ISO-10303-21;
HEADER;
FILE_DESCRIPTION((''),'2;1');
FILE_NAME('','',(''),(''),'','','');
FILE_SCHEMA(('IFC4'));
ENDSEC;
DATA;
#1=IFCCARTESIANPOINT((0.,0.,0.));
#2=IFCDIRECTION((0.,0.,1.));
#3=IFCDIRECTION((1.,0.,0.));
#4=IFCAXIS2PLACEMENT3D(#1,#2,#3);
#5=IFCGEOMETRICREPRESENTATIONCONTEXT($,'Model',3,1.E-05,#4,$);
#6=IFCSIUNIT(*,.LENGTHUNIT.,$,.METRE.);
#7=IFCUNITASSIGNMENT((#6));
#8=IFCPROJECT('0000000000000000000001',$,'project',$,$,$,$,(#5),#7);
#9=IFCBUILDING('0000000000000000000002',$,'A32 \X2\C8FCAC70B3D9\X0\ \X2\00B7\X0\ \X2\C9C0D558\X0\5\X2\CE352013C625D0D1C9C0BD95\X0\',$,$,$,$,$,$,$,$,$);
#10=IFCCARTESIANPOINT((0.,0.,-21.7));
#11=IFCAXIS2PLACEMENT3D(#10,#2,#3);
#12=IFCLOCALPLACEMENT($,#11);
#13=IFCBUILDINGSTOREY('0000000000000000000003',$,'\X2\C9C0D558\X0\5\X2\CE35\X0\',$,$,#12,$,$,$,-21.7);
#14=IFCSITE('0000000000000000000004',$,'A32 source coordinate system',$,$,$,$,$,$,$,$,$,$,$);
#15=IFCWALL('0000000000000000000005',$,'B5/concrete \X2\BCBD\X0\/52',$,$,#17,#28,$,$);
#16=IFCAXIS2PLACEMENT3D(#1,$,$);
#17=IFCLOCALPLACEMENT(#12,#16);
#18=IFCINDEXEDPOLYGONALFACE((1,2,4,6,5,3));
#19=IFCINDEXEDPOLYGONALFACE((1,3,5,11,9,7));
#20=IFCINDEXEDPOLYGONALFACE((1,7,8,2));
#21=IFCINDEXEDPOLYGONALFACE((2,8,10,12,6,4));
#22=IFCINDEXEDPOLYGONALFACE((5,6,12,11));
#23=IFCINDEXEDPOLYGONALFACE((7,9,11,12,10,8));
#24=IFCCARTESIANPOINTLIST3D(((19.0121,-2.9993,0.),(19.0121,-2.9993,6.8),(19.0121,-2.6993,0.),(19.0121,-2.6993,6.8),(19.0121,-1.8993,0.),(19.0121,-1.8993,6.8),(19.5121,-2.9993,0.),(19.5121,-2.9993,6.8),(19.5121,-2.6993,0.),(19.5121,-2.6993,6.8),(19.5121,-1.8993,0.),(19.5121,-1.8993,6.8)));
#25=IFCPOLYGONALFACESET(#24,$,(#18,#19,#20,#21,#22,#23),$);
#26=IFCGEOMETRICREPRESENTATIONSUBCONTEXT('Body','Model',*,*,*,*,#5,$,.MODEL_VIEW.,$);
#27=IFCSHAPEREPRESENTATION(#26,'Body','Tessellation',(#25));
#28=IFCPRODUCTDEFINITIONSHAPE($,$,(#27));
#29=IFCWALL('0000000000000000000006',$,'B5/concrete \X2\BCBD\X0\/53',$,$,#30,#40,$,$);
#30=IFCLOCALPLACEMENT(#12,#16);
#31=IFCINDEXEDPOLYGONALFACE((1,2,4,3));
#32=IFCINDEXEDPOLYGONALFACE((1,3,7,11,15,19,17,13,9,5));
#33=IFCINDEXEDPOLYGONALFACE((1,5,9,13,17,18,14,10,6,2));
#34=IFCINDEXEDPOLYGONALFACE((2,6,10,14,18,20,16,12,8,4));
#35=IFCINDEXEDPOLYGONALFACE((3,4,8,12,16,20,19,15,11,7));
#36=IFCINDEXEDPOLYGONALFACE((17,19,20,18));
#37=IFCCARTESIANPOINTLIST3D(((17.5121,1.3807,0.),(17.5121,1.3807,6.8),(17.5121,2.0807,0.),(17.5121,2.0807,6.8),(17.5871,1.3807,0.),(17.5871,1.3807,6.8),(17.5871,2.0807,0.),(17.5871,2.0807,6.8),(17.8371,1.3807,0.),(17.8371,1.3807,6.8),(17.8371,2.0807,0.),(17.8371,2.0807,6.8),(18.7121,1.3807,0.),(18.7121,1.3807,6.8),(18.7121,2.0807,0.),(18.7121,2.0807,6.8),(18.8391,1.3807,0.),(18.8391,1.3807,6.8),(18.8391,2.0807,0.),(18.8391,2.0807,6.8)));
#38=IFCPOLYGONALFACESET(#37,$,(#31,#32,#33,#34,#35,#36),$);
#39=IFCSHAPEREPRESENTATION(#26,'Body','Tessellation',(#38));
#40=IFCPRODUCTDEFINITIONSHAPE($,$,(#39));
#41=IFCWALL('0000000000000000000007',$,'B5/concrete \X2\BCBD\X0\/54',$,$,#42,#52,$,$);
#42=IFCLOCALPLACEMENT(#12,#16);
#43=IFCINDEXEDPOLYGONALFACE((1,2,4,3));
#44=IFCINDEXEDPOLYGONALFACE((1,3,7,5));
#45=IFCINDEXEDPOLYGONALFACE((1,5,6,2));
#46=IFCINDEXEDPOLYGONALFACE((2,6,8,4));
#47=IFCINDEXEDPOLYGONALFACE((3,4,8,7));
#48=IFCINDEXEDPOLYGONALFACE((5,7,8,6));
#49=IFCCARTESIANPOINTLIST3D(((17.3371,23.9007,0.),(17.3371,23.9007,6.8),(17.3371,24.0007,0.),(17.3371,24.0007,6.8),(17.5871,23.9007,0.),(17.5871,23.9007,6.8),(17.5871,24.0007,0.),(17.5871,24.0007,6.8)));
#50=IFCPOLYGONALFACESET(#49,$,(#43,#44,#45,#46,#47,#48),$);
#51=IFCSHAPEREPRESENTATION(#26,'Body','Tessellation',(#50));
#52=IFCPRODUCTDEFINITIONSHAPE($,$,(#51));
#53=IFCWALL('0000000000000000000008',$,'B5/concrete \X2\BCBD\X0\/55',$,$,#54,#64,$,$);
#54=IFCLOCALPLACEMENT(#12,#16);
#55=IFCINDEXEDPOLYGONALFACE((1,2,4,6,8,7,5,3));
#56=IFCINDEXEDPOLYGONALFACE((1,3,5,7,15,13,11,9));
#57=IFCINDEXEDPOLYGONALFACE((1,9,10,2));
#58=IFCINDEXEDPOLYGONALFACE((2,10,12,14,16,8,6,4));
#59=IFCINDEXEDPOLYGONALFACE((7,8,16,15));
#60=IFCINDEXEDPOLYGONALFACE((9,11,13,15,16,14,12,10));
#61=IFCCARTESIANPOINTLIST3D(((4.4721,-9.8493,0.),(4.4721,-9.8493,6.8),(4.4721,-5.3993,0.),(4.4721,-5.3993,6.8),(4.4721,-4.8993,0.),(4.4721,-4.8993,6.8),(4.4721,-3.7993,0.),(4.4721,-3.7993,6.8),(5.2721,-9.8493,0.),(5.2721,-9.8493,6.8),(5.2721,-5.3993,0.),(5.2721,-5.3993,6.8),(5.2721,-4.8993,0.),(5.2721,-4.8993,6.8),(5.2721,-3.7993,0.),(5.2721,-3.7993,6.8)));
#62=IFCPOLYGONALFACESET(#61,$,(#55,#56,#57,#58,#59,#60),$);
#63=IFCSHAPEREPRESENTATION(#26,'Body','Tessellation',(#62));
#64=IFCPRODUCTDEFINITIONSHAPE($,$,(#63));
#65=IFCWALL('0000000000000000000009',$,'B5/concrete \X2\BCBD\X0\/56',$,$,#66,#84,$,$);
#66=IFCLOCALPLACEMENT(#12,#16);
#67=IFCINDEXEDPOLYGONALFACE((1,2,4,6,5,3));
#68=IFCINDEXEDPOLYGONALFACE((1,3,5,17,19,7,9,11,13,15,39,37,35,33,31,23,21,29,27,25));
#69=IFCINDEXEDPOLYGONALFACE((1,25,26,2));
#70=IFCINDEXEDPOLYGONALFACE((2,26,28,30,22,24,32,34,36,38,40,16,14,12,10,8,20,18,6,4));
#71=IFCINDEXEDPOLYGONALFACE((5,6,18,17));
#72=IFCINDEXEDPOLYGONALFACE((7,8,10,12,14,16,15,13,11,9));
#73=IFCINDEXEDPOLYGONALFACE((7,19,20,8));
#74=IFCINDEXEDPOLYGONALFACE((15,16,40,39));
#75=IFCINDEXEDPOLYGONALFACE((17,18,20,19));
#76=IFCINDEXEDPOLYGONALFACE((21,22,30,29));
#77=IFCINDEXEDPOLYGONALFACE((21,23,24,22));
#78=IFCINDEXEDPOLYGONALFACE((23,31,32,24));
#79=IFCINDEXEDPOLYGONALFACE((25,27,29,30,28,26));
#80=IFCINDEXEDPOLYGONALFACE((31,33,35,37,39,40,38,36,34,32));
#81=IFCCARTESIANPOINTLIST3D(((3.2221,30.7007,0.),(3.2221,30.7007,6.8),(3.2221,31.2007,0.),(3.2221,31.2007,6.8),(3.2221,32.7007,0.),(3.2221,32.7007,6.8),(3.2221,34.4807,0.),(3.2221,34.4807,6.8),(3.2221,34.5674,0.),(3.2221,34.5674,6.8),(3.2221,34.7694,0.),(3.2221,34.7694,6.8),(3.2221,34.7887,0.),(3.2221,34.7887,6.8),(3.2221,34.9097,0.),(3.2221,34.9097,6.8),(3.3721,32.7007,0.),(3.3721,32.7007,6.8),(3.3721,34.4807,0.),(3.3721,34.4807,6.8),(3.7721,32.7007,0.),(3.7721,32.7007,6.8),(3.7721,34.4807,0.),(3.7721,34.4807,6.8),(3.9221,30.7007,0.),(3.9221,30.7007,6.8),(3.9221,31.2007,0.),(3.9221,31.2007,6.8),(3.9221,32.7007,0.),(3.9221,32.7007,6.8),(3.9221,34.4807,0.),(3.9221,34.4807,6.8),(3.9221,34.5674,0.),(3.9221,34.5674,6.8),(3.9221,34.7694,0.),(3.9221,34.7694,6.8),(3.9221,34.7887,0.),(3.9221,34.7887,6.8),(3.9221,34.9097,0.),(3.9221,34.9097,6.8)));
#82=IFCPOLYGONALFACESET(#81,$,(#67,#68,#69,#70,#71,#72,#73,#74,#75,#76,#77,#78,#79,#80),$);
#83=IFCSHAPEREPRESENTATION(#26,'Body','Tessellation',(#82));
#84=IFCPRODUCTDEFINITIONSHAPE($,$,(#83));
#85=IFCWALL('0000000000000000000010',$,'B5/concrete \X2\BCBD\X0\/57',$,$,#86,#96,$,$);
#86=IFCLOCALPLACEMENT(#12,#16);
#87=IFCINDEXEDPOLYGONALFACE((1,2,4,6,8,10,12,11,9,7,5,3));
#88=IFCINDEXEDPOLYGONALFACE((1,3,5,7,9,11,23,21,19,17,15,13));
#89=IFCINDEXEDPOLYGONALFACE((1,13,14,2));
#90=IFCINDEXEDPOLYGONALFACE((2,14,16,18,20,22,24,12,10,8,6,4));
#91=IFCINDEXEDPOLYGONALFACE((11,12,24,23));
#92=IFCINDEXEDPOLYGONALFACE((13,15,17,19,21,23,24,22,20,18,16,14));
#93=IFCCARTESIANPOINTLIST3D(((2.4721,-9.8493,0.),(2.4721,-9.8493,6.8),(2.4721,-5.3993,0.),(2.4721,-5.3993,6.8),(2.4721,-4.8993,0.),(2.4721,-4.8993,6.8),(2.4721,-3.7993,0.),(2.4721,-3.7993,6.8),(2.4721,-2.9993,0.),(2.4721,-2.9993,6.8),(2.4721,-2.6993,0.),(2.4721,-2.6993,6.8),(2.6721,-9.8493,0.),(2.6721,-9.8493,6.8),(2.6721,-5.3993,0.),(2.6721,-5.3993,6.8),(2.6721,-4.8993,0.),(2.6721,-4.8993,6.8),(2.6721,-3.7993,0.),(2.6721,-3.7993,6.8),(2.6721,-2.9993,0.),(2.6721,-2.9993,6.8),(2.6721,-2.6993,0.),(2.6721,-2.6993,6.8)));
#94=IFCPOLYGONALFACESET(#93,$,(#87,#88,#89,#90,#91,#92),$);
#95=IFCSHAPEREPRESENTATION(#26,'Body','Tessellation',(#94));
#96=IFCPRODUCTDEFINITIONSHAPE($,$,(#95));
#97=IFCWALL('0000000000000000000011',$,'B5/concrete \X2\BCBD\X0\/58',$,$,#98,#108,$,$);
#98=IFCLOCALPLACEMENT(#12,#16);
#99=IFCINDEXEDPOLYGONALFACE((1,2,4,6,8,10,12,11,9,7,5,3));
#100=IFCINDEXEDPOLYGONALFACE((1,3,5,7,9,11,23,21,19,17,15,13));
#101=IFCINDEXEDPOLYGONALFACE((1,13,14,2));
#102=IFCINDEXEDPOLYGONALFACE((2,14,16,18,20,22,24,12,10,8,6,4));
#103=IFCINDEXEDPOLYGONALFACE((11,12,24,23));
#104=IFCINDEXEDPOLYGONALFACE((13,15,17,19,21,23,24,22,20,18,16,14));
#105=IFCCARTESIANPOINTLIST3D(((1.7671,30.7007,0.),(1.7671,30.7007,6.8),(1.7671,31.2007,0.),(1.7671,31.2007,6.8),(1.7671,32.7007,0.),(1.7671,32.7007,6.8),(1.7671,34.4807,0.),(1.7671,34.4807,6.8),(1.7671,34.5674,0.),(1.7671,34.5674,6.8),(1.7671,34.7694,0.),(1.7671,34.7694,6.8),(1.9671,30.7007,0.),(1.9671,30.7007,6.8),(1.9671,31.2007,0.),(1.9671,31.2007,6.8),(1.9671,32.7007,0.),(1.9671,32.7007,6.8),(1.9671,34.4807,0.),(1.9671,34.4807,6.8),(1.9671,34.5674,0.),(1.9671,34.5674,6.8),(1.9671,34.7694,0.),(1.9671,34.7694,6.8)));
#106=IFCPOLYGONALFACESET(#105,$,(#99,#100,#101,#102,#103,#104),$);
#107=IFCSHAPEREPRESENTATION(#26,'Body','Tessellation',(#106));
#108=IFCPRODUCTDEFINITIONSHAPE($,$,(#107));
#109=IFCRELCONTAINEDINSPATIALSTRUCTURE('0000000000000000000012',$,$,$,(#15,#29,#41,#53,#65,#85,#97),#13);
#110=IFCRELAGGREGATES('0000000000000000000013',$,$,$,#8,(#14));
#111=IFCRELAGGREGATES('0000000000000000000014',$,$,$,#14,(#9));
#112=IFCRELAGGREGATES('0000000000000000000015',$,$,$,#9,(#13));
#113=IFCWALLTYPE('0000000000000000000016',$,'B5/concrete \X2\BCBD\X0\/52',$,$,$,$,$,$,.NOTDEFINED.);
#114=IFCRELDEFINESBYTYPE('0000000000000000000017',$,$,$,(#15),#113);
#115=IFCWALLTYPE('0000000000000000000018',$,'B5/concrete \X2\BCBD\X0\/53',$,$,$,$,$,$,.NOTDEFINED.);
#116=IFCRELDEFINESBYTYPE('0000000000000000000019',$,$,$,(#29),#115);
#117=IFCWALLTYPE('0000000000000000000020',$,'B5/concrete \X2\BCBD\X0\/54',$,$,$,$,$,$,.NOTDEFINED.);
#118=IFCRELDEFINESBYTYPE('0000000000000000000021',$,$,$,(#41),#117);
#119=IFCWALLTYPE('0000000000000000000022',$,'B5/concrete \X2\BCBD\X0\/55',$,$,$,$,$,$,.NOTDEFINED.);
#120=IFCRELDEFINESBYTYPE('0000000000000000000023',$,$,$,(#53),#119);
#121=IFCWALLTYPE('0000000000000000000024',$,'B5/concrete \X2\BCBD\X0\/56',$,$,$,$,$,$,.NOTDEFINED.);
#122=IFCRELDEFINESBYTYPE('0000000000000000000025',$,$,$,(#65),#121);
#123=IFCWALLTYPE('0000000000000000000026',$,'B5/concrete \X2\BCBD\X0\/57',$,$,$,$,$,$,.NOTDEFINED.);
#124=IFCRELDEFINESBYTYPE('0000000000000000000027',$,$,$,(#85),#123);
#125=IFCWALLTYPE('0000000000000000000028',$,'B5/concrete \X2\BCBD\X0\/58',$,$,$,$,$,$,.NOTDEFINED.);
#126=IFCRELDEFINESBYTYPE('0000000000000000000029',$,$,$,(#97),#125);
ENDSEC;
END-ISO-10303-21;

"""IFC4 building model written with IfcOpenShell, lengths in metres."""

from ifc_helpers import new_model, si_unit, frame, origin, origin_with_axes, place, context, subcontext, project, spatial, polyline, outline, extrude, source, transform, mapped, type_object, type_shapes, element, save


model = new_model("IFC4")

# Units and contexts
model_context = context("Model", 3, precision=1e-05, world=origin_with_axes())
body_context = subcontext(model_context, "Body", "Model", "MODEL_VIEW")
ifc_project = project(units=[si_unit("LENGTHUNIT", "METRE")], contexts=[model_context])

# Site, building, storey
site = spatial("IfcSite", under=ifc_project, Name="A32 source coordinate system")
building = spatial("IfcBuilding", under=site, Name="A32 주거동 · 지하5층–옥탑지붕")
storey_placement = place(None, frame((0.0, 0.0, -21.7), z_axis=(0.0, 0.0, 1.0), x_axis=(1.0, 0.0, 0.0)))
storey = spatial("IfcBuildingStorey", under=building, at=storey_placement, Name="지하5층", Elevation=-21.7)

# Walls
wall_type_1 = type_object("IfcWallType", Name="B5/concrete 벽/52", PredefinedType="NOTDEFINED")
shared_shape_1 = source(origin(), body_context, "Body", "SweptSolid", [
    extrude(outline(polyline([(19.5121, -2.6993), (19.5121, -2.9993), (19.0121, -2.9993), (19.0121, -2.6993), (19.0121, -1.8993), (19.5121, -1.8993), (19.5121, -2.6993)])), origin(), (0.0, 0.0, 1.0), 6.8),
])
type_shapes(wall_type_1, [shared_shape_1])
wall_1_placement = place(storey_placement, origin_with_axes())
element("IfcWall", 1, at=wall_1_placement, inside=storey, type_object=wall_type_1, Name="B5/concrete 벽/52", context=body_context, shape_type="MappedRepresentation", body=[
    mapped(shared_shape_1, transform((0.0, 0.0, 0.0), scale=1.0)),
])
wall_type_2 = type_object("IfcWallType", Name="B5/concrete 벽/53", PredefinedType="NOTDEFINED")
shared_shape_2 = source(origin(), body_context, "Body", "SweptSolid", [
    extrude(outline(polyline([(18.8391, 1.3807), (18.7121, 1.3807), (17.8371, 1.3807), (17.5871, 1.3807), (17.5121, 1.3807), (17.5121, 2.0807), (17.5871, 2.0807), (17.8371, 2.0807), (18.7121, 2.0807), (18.8391, 2.0807), (18.8391, 1.3807)])), origin(), (0.0, 0.0, 1.0), 6.8),
])
type_shapes(wall_type_2, [shared_shape_2])
wall_2_placement = place(storey_placement, origin_with_axes())
element("IfcWall", 2, at=wall_2_placement, inside=storey, type_object=wall_type_2, Name="B5/concrete 벽/53", context=body_context, shape_type="MappedRepresentation", body=[
    mapped(shared_shape_2, transform((0.0, 0.0, 0.0), scale=1.0)),
])
wall_type_3 = type_object("IfcWallType", Name="B5/concrete 벽/54", PredefinedType="NOTDEFINED")
shared_shape_3 = source(origin(), body_context, "Body", "SweptSolid", [
    extrude(outline(polyline([(17.5871, 23.9007), (17.3371, 23.9007), (17.3371, 24.0007), (17.5871, 24.0007), (17.5871, 23.9007)])), origin(), (0.0, 0.0, 1.0), 6.8),
])
type_shapes(wall_type_3, [shared_shape_3])
wall_3_placement = place(storey_placement, origin_with_axes())
element("IfcWall", 3, at=wall_3_placement, inside=storey, type_object=wall_type_3, Name="B5/concrete 벽/54", context=body_context, shape_type="MappedRepresentation", body=[
    mapped(shared_shape_3, transform((0.0, 0.0, 0.0), scale=1.0)),
])
wall_type_4 = type_object("IfcWallType", Name="B5/concrete 벽/55", PredefinedType="NOTDEFINED")
shared_shape_4 = source(origin(), body_context, "Body", "SweptSolid", [
    extrude(outline(polyline([(4.4721, -9.8493), (4.4721, -5.3993), (4.4721, -4.8993), (4.4721, -3.7993), (5.2721, -3.7993), (5.2721, -4.8993), (5.2721, -5.3993), (5.2721, -9.8493), (4.4721, -9.8493)])), origin(), (0.0, 0.0, 1.0), 6.8),
])
type_shapes(wall_type_4, [shared_shape_4])
wall_4_placement = place(storey_placement, origin_with_axes())
element("IfcWall", 4, at=wall_4_placement, inside=storey, type_object=wall_type_4, Name="B5/concrete 벽/55", context=body_context, shape_type="MappedRepresentation", body=[
    mapped(shared_shape_4, transform((0.0, 0.0, 0.0), scale=1.0)),
])
wall_type_5 = type_object("IfcWallType", Name="B5/concrete 벽/56", PredefinedType="NOTDEFINED")
shared_shape_5 = source(origin(), body_context, "Body", "SweptSolid", [
    extrude(outline(polyline([(3.2221, 34.7694), (3.2221, 34.7887), (3.2221, 34.9097), (3.9221, 34.9097), (3.9221, 34.7887), (3.9221, 34.7694), (3.9221, 34.5674), (3.9221, 34.4807), (3.7721, 34.4807), (3.7721, 32.7007), (3.9221, 32.7007), (3.9221, 31.2007), (3.9221, 30.7007), (3.2221, 30.7007), (3.2221, 31.2007), (3.2221, 32.7007), (3.3721, 32.7007), (3.3721, 34.4807), (3.2221, 34.4807), (3.2221, 34.5674), (3.2221, 34.7694)])), origin(), (0.0, 0.0, 1.0), 6.8),
])
type_shapes(wall_type_5, [shared_shape_5])
wall_5_placement = place(storey_placement, origin_with_axes())
element("IfcWall", 5, at=wall_5_placement, inside=storey, type_object=wall_type_5, Name="B5/concrete 벽/56", context=body_context, shape_type="MappedRepresentation", body=[
    mapped(shared_shape_5, transform((0.0, 0.0, 0.0), scale=1.0)),
])
wall_type_6 = type_object("IfcWallType", Name="B5/concrete 벽/57", PredefinedType="NOTDEFINED")
shared_shape_6 = source(origin(), body_context, "Body", "SweptSolid", [
    extrude(outline(polyline([(2.6721, -3.7993), (2.6721, -4.8993), (2.6721, -5.3993), (2.6721, -9.8493), (2.4721, -9.8493), (2.4721, -5.3993), (2.4721, -4.8993), (2.4721, -3.7993), (2.4721, -2.9993), (2.4721, -2.6993), (2.6721, -2.6993), (2.6721, -2.9993), (2.6721, -3.7993)])), origin(), (0.0, 0.0, 1.0), 6.8),
])
type_shapes(wall_type_6, [shared_shape_6])
wall_6_placement = place(storey_placement, origin_with_axes())
element("IfcWall", 6, at=wall_6_placement, inside=storey, type_object=wall_type_6, Name="B5/concrete 벽/57", context=body_context, shape_type="MappedRepresentation", body=[
    mapped(shared_shape_6, transform((0.0, 0.0, 0.0), scale=1.0)),
])
wall_type_7 = type_object("IfcWallType", Name="B5/concrete 벽/58", PredefinedType="NOTDEFINED")
shared_shape_7 = source(origin(), body_context, "Body", "SweptSolid", [
    extrude(outline(polyline([(1.9671, 30.7007), (1.7671, 30.7007), (1.7671, 31.2007), (1.7671, 32.7007), (1.7671, 34.4807), (1.7671, 34.5674), (1.7671, 34.7694), (1.9671, 34.7694), (1.9671, 34.5674), (1.9671, 34.4807), (1.9671, 32.7007), (1.9671, 31.2007), (1.9671, 30.7007)])), origin(), (0.0, 0.0, 1.0), 6.8),
])
type_shapes(wall_type_7, [shared_shape_7])
wall_7_placement = place(storey_placement, origin_with_axes())
element("IfcWall", 7, at=wall_7_placement, inside=storey, type_object=wall_type_7, Name="B5/concrete 벽/58", context=body_context, shape_type="MappedRepresentation", body=[
    mapped(shared_shape_7, transform((0.0, 0.0, 0.0), scale=1.0)),
])

save(model, "model.ifc")
